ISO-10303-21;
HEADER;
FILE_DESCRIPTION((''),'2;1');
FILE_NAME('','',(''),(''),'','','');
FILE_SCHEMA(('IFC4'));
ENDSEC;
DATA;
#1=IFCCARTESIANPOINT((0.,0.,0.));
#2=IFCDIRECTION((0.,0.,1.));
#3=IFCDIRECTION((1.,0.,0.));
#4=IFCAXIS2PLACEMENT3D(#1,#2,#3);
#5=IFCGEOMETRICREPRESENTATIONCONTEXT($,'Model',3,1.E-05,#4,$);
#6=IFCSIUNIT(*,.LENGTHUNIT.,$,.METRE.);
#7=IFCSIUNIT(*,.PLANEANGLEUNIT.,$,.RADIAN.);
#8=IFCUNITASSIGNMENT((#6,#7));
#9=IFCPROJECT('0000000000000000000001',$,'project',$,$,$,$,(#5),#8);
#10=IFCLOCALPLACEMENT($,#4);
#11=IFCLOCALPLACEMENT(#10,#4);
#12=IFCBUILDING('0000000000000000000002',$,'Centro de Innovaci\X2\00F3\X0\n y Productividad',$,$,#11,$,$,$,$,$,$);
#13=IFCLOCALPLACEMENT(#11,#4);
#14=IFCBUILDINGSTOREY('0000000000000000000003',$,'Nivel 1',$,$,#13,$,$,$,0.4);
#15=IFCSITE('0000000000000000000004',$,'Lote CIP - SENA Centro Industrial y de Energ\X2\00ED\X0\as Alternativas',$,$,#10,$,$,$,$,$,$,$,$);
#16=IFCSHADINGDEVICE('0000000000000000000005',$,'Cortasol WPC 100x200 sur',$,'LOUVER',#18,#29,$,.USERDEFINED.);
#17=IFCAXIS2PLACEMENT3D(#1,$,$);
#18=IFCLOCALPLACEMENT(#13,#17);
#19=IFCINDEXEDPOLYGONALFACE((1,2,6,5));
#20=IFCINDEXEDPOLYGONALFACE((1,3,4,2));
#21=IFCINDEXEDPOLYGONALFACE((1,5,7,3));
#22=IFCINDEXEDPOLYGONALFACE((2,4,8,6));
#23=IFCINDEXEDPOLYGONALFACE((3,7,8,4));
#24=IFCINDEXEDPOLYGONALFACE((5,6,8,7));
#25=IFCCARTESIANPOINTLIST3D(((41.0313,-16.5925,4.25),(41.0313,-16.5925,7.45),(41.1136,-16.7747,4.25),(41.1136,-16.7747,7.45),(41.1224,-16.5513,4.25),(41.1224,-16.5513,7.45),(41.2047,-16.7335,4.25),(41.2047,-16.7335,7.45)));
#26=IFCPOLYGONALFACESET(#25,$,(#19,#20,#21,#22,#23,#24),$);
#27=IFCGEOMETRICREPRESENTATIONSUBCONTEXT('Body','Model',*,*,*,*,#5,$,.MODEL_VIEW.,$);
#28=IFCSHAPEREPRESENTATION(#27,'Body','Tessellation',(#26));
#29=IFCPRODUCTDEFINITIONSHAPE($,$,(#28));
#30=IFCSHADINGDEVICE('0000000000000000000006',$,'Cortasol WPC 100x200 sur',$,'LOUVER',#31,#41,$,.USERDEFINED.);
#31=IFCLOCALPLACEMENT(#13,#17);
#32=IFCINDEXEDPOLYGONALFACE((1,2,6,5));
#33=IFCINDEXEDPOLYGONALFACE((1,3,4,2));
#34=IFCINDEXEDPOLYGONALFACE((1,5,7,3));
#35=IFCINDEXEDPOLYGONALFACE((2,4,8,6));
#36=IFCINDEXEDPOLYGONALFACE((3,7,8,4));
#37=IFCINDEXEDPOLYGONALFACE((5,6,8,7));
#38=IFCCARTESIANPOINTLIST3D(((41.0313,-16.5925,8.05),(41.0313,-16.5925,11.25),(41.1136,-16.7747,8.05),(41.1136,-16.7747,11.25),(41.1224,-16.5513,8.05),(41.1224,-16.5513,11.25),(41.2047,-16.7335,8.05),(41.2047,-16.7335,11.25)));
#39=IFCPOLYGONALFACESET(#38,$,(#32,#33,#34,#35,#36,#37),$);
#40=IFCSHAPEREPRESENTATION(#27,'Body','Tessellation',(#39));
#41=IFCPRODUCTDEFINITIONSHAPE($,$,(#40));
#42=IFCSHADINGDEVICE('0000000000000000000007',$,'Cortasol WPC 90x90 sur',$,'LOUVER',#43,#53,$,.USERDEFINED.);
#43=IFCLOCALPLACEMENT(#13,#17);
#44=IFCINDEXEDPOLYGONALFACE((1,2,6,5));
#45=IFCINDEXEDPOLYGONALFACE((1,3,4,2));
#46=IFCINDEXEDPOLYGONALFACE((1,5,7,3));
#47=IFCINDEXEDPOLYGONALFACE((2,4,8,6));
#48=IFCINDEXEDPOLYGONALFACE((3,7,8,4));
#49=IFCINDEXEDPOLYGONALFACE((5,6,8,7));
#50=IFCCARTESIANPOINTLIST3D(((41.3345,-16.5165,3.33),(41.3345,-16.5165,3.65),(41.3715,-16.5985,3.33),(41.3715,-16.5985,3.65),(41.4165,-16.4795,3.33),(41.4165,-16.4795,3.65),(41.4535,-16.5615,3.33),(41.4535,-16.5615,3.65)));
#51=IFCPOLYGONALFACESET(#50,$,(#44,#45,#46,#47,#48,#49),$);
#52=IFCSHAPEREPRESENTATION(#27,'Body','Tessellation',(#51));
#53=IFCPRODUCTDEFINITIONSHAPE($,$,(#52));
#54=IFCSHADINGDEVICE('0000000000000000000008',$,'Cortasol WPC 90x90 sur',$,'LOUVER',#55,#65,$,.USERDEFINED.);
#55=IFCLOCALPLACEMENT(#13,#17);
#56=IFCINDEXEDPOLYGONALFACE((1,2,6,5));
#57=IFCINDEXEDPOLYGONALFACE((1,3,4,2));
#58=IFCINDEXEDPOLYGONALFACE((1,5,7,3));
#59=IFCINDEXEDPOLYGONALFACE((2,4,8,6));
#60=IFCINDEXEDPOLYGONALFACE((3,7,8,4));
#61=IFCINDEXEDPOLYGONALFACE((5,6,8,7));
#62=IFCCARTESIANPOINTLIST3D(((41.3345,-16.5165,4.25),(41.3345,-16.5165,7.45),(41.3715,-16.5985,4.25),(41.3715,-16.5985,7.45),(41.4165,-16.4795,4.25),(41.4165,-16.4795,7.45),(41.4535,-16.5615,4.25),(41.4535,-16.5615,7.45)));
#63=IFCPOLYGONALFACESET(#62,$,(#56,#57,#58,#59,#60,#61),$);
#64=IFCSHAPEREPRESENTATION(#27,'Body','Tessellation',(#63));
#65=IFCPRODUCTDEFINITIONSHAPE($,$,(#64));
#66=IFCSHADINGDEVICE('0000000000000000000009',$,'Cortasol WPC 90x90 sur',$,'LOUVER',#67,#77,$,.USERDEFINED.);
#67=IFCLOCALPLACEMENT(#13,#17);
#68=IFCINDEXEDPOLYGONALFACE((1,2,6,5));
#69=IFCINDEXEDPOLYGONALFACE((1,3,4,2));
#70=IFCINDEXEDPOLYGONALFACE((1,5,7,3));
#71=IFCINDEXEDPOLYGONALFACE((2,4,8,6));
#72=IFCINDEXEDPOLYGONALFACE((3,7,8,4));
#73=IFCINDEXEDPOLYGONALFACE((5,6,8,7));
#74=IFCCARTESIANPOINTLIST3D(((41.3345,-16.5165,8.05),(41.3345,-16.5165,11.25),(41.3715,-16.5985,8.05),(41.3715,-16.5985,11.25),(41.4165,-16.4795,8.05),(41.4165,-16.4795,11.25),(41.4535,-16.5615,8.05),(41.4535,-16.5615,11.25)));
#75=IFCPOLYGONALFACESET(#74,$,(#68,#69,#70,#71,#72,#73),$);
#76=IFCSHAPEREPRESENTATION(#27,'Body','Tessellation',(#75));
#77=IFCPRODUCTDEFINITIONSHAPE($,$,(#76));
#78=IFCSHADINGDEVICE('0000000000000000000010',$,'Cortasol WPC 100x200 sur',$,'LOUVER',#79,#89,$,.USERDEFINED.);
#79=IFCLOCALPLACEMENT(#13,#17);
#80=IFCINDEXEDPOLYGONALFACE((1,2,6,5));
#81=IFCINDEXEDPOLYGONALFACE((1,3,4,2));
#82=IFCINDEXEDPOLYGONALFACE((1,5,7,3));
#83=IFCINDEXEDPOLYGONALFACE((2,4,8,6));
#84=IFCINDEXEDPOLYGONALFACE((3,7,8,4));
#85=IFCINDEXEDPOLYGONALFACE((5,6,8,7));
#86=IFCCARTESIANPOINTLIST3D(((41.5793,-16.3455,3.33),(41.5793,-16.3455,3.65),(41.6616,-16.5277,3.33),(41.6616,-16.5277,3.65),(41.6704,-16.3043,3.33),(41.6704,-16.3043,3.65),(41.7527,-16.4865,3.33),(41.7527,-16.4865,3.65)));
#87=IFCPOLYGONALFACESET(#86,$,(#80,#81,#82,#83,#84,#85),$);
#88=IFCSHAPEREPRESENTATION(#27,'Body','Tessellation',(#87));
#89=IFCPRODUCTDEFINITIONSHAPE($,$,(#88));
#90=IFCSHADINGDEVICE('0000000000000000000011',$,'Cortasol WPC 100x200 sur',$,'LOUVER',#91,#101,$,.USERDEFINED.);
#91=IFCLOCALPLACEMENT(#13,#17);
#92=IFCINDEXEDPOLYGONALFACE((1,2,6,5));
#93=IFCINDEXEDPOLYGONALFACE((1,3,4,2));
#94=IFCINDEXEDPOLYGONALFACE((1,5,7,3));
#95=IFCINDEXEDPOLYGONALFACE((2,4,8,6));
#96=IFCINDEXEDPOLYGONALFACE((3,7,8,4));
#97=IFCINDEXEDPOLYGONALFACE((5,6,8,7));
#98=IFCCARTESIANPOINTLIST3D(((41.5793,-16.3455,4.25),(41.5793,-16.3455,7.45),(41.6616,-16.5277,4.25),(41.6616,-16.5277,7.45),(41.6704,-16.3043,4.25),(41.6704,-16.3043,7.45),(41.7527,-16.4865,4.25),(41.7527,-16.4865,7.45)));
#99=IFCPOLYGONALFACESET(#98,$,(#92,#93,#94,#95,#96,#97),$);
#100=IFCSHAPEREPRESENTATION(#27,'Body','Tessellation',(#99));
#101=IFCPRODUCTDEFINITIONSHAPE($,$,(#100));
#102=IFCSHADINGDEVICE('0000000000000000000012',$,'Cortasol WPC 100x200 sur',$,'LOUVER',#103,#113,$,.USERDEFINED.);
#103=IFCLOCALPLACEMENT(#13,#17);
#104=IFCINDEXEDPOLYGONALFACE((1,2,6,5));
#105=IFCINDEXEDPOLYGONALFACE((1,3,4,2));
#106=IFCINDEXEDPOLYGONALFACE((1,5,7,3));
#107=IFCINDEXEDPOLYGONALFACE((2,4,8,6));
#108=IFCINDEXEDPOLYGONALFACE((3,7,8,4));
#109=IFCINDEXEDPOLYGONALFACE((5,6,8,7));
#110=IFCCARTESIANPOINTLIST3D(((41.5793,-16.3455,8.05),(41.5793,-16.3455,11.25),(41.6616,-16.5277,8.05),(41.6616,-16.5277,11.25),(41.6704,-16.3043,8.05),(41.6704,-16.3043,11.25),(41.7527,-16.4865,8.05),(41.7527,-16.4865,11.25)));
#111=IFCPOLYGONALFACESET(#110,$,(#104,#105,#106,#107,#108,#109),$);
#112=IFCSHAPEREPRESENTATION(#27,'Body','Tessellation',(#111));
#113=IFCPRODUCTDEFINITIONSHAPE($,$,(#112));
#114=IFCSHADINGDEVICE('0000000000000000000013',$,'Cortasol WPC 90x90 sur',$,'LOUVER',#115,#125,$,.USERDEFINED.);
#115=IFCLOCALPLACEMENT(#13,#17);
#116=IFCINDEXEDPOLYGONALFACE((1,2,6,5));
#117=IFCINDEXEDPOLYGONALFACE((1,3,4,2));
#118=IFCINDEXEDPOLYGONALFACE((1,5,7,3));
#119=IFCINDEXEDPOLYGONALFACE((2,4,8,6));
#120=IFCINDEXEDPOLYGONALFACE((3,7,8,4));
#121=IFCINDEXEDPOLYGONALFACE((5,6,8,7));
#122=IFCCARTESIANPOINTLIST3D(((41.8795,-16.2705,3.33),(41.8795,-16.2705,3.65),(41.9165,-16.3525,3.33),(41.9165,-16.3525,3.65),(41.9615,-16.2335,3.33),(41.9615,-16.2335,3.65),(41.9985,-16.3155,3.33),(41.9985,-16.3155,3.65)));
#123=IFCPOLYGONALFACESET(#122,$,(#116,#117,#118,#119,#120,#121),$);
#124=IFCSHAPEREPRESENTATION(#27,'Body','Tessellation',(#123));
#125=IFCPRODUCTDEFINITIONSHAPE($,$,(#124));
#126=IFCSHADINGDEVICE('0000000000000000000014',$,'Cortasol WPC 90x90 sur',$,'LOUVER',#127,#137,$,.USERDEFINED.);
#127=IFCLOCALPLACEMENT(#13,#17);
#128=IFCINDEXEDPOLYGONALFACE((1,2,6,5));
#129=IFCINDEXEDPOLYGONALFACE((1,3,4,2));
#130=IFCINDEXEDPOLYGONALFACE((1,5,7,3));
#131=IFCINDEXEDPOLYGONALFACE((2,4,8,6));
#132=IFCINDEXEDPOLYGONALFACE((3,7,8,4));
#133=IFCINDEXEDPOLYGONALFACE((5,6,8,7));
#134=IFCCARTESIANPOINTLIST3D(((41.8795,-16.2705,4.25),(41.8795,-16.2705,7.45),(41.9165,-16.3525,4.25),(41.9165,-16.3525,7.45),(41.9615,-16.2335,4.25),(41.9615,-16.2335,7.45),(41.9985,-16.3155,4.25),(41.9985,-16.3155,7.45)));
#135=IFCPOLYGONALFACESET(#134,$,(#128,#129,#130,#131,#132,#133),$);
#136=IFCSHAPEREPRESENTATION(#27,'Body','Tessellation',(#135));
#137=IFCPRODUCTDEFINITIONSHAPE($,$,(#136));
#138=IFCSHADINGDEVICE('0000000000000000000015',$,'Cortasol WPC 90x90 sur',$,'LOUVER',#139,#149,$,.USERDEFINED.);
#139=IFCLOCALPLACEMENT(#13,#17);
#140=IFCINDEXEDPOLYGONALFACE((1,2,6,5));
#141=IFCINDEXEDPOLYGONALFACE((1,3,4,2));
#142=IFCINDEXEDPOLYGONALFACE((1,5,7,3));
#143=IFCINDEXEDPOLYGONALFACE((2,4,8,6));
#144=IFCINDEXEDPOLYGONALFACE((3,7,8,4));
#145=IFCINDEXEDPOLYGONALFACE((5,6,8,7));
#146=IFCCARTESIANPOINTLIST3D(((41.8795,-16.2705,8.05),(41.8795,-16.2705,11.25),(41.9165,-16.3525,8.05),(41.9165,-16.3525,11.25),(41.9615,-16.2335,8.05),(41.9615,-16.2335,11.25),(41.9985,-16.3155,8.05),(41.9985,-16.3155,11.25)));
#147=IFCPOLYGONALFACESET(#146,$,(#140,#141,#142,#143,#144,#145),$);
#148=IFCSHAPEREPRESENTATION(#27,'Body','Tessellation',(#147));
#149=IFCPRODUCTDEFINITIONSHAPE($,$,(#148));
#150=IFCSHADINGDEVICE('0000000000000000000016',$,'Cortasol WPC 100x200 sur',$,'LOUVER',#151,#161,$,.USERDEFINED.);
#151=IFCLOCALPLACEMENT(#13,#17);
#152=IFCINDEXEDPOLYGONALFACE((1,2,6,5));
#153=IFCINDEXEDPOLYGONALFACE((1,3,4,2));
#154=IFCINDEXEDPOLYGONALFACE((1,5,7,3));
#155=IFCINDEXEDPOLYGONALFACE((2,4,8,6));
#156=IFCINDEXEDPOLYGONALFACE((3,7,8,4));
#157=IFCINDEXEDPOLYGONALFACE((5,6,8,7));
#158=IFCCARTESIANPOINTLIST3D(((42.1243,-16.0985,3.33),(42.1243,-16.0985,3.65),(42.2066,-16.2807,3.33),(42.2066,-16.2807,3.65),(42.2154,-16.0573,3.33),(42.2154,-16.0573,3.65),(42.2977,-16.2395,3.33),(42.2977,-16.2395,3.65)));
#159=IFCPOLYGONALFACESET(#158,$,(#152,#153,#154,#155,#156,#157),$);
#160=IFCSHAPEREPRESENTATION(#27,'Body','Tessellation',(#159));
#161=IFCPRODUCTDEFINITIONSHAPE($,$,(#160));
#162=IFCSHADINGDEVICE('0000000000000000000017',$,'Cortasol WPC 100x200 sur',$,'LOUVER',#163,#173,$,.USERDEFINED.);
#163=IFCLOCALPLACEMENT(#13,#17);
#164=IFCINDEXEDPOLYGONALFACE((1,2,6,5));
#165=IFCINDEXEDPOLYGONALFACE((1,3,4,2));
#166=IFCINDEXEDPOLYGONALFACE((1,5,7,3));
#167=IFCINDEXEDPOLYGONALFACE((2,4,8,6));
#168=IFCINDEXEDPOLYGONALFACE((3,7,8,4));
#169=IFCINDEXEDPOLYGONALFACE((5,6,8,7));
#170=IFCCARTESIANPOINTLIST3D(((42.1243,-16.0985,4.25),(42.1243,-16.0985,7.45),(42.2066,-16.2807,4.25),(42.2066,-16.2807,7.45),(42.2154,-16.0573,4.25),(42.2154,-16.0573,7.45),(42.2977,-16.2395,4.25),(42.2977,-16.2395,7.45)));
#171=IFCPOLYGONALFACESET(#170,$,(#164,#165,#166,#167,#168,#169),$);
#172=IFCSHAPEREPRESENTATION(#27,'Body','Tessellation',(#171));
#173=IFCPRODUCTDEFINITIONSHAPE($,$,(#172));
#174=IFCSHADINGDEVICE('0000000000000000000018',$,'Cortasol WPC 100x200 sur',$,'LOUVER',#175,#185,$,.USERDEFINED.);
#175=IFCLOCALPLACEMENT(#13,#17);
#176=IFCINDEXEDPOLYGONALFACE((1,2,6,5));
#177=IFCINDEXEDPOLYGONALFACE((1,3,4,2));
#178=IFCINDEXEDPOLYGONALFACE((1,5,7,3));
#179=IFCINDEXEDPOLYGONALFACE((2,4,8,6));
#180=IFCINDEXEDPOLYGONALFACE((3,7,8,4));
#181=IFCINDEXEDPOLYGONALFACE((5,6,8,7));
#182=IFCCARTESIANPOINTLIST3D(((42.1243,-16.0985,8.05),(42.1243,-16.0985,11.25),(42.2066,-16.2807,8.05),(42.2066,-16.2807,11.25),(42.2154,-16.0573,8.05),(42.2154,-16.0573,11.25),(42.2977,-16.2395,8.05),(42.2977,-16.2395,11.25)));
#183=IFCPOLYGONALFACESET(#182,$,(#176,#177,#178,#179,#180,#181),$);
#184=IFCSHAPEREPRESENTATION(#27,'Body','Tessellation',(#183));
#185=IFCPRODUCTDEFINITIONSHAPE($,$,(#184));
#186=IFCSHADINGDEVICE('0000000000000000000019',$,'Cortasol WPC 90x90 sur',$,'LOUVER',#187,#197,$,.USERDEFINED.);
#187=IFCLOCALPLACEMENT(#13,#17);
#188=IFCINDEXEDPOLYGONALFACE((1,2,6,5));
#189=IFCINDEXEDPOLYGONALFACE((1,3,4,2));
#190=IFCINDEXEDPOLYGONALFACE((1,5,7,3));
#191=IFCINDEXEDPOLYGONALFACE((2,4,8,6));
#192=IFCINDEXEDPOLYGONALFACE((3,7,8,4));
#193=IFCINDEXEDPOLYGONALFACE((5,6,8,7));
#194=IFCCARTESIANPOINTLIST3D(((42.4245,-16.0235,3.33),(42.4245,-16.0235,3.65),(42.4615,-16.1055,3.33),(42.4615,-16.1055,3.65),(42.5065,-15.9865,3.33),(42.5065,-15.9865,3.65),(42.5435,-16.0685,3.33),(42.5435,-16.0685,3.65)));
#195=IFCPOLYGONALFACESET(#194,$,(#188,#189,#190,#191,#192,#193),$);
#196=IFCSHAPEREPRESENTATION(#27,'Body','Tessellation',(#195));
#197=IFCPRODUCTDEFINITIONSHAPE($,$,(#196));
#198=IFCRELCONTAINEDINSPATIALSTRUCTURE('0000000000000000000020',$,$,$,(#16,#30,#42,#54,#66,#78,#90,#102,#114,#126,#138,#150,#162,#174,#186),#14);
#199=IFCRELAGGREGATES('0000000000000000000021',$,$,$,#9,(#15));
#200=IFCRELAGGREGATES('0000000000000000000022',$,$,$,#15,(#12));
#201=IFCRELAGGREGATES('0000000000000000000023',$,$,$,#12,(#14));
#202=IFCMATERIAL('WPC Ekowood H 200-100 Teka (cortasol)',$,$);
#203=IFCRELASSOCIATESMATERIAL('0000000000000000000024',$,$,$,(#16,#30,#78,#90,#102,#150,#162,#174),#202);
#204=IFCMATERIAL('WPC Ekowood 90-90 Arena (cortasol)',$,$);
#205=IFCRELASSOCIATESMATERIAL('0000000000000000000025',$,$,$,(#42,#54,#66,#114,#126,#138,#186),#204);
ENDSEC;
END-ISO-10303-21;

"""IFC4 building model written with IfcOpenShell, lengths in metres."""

from ifc_helpers import new_model, si_unit, frame, origin_with_axes, place, context, subcontext, project, spatial, polyline, outline, extrude, material, element, save


model = new_model("IFC4")

# Units and contexts
model_context = context("Model", 3, precision=1e-05, world=origin_with_axes())
body_context = subcontext(model_context, "Body", "Model", "MODEL_VIEW")
ifc_project = project(units=[si_unit("LENGTHUNIT", "METRE"), si_unit("PLANEANGLEUNIT", "RADIAN")], contexts=[model_context])

# Site, building, storey
site_placement = place(None, origin_with_axes())
site = spatial("IfcSite", under=ifc_project, at=site_placement, Name="Lote CIP - SENA Centro Industrial y de Energías Alternativas")
building_placement = place(site_placement, origin_with_axes())
building = spatial("IfcBuilding", under=site, at=building_placement, Name="Centro de Innovación y Productividad")
storey_placement = place(building_placement, origin_with_axes())
storey = spatial("IfcBuildingStorey", under=building, at=storey_placement, Name="Nivel 1", Elevation=0.4)

# Shading devices
ifc_material_1 = material(Name="WPC Ekowood H 200-100 Teka (cortasol)")
shading_device_1_placement = place(storey_placement, origin_with_axes())
element("IfcShadingDevice", 1, at=shading_device_1_placement, inside=storey, material=ifc_material_1, Name="Cortasol WPC 100x200 sur", ObjectType="LOUVER", PredefinedType="USERDEFINED", context=body_context, shape_type="SweptSolid", body=[
    extrude(outline(polyline([(41.1136, -16.7747), (41.0313, -16.5925), (41.1224, -16.5513), (41.2047, -16.7335), (41.1136, -16.7747)])), frame((0.0, 0.0, 4.25)), (0.0, 0.0, 1.0), 3.2),
])
shading_device_2_placement = place(storey_placement, origin_with_axes())
element("IfcShadingDevice", 2, at=shading_device_2_placement, inside=storey, material=ifc_material_1, Name="Cortasol WPC 100x200 sur", ObjectType="LOUVER", PredefinedType="USERDEFINED", context=body_context, shape_type="SweptSolid", body=[
    extrude(outline(polyline([(41.1136, -16.7747), (41.0313, -16.5925), (41.1224, -16.5513), (41.2047, -16.7335), (41.1136, -16.7747)])), frame((0.0, 0.0, 8.05)), (0.0, 0.0, 1.0), 3.2),
])
ifc_material_2 = material(Name="WPC Ekowood 90-90 Arena (cortasol)")
shading_device_3_placement = place(storey_placement, origin_with_axes())
element("IfcShadingDevice", 3, at=shading_device_3_placement, inside=storey, material=ifc_material_2, Name="Cortasol WPC 90x90 sur", ObjectType="LOUVER", PredefinedType="USERDEFINED", context=body_context, shape_type="SweptSolid", body=[
    extrude(outline(polyline([(41.3715, -16.5985), (41.3345, -16.5165), (41.4165, -16.4795), (41.4535, -16.5615), (41.3715, -16.5985)])), frame((0.0, 0.0, 3.33)), (0.0, 0.0, 1.0), 0.32),
])
shading_device_4_placement = place(storey_placement, origin_with_axes())
element("IfcShadingDevice", 4, at=shading_device_4_placement, inside=storey, material=ifc_material_2, Name="Cortasol WPC 90x90 sur", ObjectType="LOUVER", PredefinedType="USERDEFINED", context=body_context, shape_type="SweptSolid", body=[
    extrude(outline(polyline([(41.3715, -16.5985), (41.3345, -16.5165), (41.4165, -16.4795), (41.4535, -16.5615), (41.3715, -16.5985)])), frame((0.0, 0.0, 4.25)), (0.0, 0.0, 1.0), 3.2),
])
shading_device_5_placement = place(storey_placement, origin_with_axes())
element("IfcShadingDevice", 5, at=shading_device_5_placement, inside=storey, material=ifc_material_2, Name="Cortasol WPC 90x90 sur", ObjectType="LOUVER", PredefinedType="USERDEFINED", context=body_context, shape_type="SweptSolid", body=[
    extrude(outline(polyline([(41.3715, -16.5985), (41.3345, -16.5165), (41.4165, -16.4795), (41.4535, -16.5615), (41.3715, -16.5985)])), frame((0.0, 0.0, 8.05)), (0.0, 0.0, 1.0), 3.2),
])
shading_device_6_placement = place(storey_placement, origin_with_axes())
element("IfcShadingDevice", 6, at=shading_device_6_placement, inside=storey, material=ifc_material_1, Name="Cortasol WPC 100x200 sur", ObjectType="LOUVER", PredefinedType="USERDEFINED", context=body_context, shape_type="SweptSolid", body=[
    extrude(outline(polyline([(41.6616, -16.5277), (41.5793, -16.3455), (41.6704, -16.3043), (41.7527, -16.4865), (41.6616, -16.5277)])), frame((0.0, 0.0, 3.33)), (0.0, 0.0, 1.0), 0.32),
])
shading_device_7_placement = place(storey_placement, origin_with_axes())
element("IfcShadingDevice", 7, at=shading_device_7_placement, inside=storey, material=ifc_material_1, Name="Cortasol WPC 100x200 sur", ObjectType="LOUVER", PredefinedType="USERDEFINED", context=body_context, shape_type="SweptSolid", body=[
    extrude(outline(polyline([(41.6616, -16.5277), (41.5793, -16.3455), (41.6704, -16.3043), (41.7527, -16.4865), (41.6616, -16.5277)])), frame((0.0, 0.0, 4.25)), (0.0, 0.0, 1.0), 3.2),
])
shading_device_8_placement = place(storey_placement, origin_with_axes())
element("IfcShadingDevice", 8, at=shading_device_8_placement, inside=storey, material=ifc_material_1, Name="Cortasol WPC 100x200 sur", ObjectType="LOUVER", PredefinedType="USERDEFINED", context=body_context, shape_type="SweptSolid", body=[
    extrude(outline(polyline([(41.6616, -16.5277), (41.5793, -16.3455), (41.6704, -16.3043), (41.7527, -16.4865), (41.6616, -16.5277)])), frame((0.0, 0.0, 8.05)), (0.0, 0.0, 1.0), 3.2),
])
shading_device_9_placement = place(storey_placement, origin_with_axes())
element("IfcShadingDevice", 9, at=shading_device_9_placement, inside=storey, material=ifc_material_2, Name="Cortasol WPC 90x90 sur", ObjectType="LOUVER", PredefinedType="USERDEFINED", context=body_context, shape_type="SweptSolid", body=[
    extrude(outline(polyline([(41.9165, -16.3525), (41.8795, -16.2705), (41.9615, -16.2335), (41.9985, -16.3155), (41.9165, -16.3525)])), frame((0.0, 0.0, 3.33)), (0.0, 0.0, 1.0), 0.32),
])
shading_device_10_placement = place(storey_placement, origin_with_axes())
element("IfcShadingDevice", 10, at=shading_device_10_placement, inside=storey, material=ifc_material_2, Name="Cortasol WPC 90x90 sur", ObjectType="LOUVER", PredefinedType="USERDEFINED", context=body_context, shape_type="SweptSolid", body=[
    extrude(outline(polyline([(41.9165, -16.3525), (41.8795, -16.2705), (41.9615, -16.2335), (41.9985, -16.3155), (41.9165, -16.3525)])), frame((0.0, 0.0, 4.25)), (0.0, 0.0, 1.0), 3.2),
])
shading_device_11_placement = place(storey_placement, origin_with_axes())
element("IfcShadingDevice", 11, at=shading_device_11_placement, inside=storey, material=ifc_material_2, Name="Cortasol WPC 90x90 sur", ObjectType="LOUVER", PredefinedType="USERDEFINED", context=body_context, shape_type="SweptSolid", body=[
    extrude(outline(polyline([(41.9165, -16.3525), (41.8795, -16.2705), (41.9615, -16.2335), (41.9985, -16.3155), (41.9165, -16.3525)])), frame((0.0, 0.0, 8.05)), (0.0, 0.0, 1.0), 3.2),
])
shading_device_12_placement = place(storey_placement, origin_with_axes())
element("IfcShadingDevice", 12, at=shading_device_12_placement, inside=storey, material=ifc_material_1, Name="Cortasol WPC 100x200 sur", ObjectType="LOUVER", PredefinedType="USERDEFINED", context=body_context, shape_type="SweptSolid", body=[
    extrude(outline(polyline([(42.2066, -16.2807), (42.1243, -16.0985), (42.2154, -16.0573), (42.2977, -16.2395), (42.2066, -16.2807)])), frame((0.0, 0.0, 3.33)), (0.0, 0.0, 1.0), 0.32),
])
shading_device_13_placement = place(storey_placement, origin_with_axes())
element("IfcShadingDevice", 13, at=shading_device_13_placement, inside=storey, material=ifc_material_1, Name="Cortasol WPC 100x200 sur", ObjectType="LOUVER", PredefinedType="USERDEFINED", context=body_context, shape_type="SweptSolid", body=[
    extrude(outline(polyline([(42.2066, -16.2807), (42.1243, -16.0985), (42.2154, -16.0573), (42.2977, -16.2395), (42.2066, -16.2807)])), frame((0.0, 0.0, 4.25)), (0.0, 0.0, 1.0), 3.2),
])
shading_device_14_placement = place(storey_placement, origin_with_axes())
element("IfcShadingDevice", 14, at=shading_device_14_placement, inside=storey, material=ifc_material_1, Name="Cortasol WPC 100x200 sur", ObjectType="LOUVER", PredefinedType="USERDEFINED", context=body_context, shape_type="SweptSolid", body=[
    extrude(outline(polyline([(42.2066, -16.2807), (42.1243, -16.0985), (42.2154, -16.0573), (42.2977, -16.2395), (42.2066, -16.2807)])), frame((0.0, 0.0, 8.05)), (0.0, 0.0, 1.0), 3.2),
])
shading_device_15_placement = place(storey_placement, origin_with_axes())
element("IfcShadingDevice", 15, at=shading_device_15_placement, inside=storey, material=ifc_material_2, Name="Cortasol WPC 90x90 sur", ObjectType="LOUVER", PredefinedType="USERDEFINED", context=body_context, shape_type="SweptSolid", body=[
    extrude(outline(polyline([(42.4615, -16.1055), (42.4245, -16.0235), (42.5065, -15.9865), (42.5435, -16.0685), (42.4615, -16.1055)])), frame((0.0, 0.0, 3.33)), (0.0, 0.0, 1.0), 0.32),
])

save(model, "model.ifc")
